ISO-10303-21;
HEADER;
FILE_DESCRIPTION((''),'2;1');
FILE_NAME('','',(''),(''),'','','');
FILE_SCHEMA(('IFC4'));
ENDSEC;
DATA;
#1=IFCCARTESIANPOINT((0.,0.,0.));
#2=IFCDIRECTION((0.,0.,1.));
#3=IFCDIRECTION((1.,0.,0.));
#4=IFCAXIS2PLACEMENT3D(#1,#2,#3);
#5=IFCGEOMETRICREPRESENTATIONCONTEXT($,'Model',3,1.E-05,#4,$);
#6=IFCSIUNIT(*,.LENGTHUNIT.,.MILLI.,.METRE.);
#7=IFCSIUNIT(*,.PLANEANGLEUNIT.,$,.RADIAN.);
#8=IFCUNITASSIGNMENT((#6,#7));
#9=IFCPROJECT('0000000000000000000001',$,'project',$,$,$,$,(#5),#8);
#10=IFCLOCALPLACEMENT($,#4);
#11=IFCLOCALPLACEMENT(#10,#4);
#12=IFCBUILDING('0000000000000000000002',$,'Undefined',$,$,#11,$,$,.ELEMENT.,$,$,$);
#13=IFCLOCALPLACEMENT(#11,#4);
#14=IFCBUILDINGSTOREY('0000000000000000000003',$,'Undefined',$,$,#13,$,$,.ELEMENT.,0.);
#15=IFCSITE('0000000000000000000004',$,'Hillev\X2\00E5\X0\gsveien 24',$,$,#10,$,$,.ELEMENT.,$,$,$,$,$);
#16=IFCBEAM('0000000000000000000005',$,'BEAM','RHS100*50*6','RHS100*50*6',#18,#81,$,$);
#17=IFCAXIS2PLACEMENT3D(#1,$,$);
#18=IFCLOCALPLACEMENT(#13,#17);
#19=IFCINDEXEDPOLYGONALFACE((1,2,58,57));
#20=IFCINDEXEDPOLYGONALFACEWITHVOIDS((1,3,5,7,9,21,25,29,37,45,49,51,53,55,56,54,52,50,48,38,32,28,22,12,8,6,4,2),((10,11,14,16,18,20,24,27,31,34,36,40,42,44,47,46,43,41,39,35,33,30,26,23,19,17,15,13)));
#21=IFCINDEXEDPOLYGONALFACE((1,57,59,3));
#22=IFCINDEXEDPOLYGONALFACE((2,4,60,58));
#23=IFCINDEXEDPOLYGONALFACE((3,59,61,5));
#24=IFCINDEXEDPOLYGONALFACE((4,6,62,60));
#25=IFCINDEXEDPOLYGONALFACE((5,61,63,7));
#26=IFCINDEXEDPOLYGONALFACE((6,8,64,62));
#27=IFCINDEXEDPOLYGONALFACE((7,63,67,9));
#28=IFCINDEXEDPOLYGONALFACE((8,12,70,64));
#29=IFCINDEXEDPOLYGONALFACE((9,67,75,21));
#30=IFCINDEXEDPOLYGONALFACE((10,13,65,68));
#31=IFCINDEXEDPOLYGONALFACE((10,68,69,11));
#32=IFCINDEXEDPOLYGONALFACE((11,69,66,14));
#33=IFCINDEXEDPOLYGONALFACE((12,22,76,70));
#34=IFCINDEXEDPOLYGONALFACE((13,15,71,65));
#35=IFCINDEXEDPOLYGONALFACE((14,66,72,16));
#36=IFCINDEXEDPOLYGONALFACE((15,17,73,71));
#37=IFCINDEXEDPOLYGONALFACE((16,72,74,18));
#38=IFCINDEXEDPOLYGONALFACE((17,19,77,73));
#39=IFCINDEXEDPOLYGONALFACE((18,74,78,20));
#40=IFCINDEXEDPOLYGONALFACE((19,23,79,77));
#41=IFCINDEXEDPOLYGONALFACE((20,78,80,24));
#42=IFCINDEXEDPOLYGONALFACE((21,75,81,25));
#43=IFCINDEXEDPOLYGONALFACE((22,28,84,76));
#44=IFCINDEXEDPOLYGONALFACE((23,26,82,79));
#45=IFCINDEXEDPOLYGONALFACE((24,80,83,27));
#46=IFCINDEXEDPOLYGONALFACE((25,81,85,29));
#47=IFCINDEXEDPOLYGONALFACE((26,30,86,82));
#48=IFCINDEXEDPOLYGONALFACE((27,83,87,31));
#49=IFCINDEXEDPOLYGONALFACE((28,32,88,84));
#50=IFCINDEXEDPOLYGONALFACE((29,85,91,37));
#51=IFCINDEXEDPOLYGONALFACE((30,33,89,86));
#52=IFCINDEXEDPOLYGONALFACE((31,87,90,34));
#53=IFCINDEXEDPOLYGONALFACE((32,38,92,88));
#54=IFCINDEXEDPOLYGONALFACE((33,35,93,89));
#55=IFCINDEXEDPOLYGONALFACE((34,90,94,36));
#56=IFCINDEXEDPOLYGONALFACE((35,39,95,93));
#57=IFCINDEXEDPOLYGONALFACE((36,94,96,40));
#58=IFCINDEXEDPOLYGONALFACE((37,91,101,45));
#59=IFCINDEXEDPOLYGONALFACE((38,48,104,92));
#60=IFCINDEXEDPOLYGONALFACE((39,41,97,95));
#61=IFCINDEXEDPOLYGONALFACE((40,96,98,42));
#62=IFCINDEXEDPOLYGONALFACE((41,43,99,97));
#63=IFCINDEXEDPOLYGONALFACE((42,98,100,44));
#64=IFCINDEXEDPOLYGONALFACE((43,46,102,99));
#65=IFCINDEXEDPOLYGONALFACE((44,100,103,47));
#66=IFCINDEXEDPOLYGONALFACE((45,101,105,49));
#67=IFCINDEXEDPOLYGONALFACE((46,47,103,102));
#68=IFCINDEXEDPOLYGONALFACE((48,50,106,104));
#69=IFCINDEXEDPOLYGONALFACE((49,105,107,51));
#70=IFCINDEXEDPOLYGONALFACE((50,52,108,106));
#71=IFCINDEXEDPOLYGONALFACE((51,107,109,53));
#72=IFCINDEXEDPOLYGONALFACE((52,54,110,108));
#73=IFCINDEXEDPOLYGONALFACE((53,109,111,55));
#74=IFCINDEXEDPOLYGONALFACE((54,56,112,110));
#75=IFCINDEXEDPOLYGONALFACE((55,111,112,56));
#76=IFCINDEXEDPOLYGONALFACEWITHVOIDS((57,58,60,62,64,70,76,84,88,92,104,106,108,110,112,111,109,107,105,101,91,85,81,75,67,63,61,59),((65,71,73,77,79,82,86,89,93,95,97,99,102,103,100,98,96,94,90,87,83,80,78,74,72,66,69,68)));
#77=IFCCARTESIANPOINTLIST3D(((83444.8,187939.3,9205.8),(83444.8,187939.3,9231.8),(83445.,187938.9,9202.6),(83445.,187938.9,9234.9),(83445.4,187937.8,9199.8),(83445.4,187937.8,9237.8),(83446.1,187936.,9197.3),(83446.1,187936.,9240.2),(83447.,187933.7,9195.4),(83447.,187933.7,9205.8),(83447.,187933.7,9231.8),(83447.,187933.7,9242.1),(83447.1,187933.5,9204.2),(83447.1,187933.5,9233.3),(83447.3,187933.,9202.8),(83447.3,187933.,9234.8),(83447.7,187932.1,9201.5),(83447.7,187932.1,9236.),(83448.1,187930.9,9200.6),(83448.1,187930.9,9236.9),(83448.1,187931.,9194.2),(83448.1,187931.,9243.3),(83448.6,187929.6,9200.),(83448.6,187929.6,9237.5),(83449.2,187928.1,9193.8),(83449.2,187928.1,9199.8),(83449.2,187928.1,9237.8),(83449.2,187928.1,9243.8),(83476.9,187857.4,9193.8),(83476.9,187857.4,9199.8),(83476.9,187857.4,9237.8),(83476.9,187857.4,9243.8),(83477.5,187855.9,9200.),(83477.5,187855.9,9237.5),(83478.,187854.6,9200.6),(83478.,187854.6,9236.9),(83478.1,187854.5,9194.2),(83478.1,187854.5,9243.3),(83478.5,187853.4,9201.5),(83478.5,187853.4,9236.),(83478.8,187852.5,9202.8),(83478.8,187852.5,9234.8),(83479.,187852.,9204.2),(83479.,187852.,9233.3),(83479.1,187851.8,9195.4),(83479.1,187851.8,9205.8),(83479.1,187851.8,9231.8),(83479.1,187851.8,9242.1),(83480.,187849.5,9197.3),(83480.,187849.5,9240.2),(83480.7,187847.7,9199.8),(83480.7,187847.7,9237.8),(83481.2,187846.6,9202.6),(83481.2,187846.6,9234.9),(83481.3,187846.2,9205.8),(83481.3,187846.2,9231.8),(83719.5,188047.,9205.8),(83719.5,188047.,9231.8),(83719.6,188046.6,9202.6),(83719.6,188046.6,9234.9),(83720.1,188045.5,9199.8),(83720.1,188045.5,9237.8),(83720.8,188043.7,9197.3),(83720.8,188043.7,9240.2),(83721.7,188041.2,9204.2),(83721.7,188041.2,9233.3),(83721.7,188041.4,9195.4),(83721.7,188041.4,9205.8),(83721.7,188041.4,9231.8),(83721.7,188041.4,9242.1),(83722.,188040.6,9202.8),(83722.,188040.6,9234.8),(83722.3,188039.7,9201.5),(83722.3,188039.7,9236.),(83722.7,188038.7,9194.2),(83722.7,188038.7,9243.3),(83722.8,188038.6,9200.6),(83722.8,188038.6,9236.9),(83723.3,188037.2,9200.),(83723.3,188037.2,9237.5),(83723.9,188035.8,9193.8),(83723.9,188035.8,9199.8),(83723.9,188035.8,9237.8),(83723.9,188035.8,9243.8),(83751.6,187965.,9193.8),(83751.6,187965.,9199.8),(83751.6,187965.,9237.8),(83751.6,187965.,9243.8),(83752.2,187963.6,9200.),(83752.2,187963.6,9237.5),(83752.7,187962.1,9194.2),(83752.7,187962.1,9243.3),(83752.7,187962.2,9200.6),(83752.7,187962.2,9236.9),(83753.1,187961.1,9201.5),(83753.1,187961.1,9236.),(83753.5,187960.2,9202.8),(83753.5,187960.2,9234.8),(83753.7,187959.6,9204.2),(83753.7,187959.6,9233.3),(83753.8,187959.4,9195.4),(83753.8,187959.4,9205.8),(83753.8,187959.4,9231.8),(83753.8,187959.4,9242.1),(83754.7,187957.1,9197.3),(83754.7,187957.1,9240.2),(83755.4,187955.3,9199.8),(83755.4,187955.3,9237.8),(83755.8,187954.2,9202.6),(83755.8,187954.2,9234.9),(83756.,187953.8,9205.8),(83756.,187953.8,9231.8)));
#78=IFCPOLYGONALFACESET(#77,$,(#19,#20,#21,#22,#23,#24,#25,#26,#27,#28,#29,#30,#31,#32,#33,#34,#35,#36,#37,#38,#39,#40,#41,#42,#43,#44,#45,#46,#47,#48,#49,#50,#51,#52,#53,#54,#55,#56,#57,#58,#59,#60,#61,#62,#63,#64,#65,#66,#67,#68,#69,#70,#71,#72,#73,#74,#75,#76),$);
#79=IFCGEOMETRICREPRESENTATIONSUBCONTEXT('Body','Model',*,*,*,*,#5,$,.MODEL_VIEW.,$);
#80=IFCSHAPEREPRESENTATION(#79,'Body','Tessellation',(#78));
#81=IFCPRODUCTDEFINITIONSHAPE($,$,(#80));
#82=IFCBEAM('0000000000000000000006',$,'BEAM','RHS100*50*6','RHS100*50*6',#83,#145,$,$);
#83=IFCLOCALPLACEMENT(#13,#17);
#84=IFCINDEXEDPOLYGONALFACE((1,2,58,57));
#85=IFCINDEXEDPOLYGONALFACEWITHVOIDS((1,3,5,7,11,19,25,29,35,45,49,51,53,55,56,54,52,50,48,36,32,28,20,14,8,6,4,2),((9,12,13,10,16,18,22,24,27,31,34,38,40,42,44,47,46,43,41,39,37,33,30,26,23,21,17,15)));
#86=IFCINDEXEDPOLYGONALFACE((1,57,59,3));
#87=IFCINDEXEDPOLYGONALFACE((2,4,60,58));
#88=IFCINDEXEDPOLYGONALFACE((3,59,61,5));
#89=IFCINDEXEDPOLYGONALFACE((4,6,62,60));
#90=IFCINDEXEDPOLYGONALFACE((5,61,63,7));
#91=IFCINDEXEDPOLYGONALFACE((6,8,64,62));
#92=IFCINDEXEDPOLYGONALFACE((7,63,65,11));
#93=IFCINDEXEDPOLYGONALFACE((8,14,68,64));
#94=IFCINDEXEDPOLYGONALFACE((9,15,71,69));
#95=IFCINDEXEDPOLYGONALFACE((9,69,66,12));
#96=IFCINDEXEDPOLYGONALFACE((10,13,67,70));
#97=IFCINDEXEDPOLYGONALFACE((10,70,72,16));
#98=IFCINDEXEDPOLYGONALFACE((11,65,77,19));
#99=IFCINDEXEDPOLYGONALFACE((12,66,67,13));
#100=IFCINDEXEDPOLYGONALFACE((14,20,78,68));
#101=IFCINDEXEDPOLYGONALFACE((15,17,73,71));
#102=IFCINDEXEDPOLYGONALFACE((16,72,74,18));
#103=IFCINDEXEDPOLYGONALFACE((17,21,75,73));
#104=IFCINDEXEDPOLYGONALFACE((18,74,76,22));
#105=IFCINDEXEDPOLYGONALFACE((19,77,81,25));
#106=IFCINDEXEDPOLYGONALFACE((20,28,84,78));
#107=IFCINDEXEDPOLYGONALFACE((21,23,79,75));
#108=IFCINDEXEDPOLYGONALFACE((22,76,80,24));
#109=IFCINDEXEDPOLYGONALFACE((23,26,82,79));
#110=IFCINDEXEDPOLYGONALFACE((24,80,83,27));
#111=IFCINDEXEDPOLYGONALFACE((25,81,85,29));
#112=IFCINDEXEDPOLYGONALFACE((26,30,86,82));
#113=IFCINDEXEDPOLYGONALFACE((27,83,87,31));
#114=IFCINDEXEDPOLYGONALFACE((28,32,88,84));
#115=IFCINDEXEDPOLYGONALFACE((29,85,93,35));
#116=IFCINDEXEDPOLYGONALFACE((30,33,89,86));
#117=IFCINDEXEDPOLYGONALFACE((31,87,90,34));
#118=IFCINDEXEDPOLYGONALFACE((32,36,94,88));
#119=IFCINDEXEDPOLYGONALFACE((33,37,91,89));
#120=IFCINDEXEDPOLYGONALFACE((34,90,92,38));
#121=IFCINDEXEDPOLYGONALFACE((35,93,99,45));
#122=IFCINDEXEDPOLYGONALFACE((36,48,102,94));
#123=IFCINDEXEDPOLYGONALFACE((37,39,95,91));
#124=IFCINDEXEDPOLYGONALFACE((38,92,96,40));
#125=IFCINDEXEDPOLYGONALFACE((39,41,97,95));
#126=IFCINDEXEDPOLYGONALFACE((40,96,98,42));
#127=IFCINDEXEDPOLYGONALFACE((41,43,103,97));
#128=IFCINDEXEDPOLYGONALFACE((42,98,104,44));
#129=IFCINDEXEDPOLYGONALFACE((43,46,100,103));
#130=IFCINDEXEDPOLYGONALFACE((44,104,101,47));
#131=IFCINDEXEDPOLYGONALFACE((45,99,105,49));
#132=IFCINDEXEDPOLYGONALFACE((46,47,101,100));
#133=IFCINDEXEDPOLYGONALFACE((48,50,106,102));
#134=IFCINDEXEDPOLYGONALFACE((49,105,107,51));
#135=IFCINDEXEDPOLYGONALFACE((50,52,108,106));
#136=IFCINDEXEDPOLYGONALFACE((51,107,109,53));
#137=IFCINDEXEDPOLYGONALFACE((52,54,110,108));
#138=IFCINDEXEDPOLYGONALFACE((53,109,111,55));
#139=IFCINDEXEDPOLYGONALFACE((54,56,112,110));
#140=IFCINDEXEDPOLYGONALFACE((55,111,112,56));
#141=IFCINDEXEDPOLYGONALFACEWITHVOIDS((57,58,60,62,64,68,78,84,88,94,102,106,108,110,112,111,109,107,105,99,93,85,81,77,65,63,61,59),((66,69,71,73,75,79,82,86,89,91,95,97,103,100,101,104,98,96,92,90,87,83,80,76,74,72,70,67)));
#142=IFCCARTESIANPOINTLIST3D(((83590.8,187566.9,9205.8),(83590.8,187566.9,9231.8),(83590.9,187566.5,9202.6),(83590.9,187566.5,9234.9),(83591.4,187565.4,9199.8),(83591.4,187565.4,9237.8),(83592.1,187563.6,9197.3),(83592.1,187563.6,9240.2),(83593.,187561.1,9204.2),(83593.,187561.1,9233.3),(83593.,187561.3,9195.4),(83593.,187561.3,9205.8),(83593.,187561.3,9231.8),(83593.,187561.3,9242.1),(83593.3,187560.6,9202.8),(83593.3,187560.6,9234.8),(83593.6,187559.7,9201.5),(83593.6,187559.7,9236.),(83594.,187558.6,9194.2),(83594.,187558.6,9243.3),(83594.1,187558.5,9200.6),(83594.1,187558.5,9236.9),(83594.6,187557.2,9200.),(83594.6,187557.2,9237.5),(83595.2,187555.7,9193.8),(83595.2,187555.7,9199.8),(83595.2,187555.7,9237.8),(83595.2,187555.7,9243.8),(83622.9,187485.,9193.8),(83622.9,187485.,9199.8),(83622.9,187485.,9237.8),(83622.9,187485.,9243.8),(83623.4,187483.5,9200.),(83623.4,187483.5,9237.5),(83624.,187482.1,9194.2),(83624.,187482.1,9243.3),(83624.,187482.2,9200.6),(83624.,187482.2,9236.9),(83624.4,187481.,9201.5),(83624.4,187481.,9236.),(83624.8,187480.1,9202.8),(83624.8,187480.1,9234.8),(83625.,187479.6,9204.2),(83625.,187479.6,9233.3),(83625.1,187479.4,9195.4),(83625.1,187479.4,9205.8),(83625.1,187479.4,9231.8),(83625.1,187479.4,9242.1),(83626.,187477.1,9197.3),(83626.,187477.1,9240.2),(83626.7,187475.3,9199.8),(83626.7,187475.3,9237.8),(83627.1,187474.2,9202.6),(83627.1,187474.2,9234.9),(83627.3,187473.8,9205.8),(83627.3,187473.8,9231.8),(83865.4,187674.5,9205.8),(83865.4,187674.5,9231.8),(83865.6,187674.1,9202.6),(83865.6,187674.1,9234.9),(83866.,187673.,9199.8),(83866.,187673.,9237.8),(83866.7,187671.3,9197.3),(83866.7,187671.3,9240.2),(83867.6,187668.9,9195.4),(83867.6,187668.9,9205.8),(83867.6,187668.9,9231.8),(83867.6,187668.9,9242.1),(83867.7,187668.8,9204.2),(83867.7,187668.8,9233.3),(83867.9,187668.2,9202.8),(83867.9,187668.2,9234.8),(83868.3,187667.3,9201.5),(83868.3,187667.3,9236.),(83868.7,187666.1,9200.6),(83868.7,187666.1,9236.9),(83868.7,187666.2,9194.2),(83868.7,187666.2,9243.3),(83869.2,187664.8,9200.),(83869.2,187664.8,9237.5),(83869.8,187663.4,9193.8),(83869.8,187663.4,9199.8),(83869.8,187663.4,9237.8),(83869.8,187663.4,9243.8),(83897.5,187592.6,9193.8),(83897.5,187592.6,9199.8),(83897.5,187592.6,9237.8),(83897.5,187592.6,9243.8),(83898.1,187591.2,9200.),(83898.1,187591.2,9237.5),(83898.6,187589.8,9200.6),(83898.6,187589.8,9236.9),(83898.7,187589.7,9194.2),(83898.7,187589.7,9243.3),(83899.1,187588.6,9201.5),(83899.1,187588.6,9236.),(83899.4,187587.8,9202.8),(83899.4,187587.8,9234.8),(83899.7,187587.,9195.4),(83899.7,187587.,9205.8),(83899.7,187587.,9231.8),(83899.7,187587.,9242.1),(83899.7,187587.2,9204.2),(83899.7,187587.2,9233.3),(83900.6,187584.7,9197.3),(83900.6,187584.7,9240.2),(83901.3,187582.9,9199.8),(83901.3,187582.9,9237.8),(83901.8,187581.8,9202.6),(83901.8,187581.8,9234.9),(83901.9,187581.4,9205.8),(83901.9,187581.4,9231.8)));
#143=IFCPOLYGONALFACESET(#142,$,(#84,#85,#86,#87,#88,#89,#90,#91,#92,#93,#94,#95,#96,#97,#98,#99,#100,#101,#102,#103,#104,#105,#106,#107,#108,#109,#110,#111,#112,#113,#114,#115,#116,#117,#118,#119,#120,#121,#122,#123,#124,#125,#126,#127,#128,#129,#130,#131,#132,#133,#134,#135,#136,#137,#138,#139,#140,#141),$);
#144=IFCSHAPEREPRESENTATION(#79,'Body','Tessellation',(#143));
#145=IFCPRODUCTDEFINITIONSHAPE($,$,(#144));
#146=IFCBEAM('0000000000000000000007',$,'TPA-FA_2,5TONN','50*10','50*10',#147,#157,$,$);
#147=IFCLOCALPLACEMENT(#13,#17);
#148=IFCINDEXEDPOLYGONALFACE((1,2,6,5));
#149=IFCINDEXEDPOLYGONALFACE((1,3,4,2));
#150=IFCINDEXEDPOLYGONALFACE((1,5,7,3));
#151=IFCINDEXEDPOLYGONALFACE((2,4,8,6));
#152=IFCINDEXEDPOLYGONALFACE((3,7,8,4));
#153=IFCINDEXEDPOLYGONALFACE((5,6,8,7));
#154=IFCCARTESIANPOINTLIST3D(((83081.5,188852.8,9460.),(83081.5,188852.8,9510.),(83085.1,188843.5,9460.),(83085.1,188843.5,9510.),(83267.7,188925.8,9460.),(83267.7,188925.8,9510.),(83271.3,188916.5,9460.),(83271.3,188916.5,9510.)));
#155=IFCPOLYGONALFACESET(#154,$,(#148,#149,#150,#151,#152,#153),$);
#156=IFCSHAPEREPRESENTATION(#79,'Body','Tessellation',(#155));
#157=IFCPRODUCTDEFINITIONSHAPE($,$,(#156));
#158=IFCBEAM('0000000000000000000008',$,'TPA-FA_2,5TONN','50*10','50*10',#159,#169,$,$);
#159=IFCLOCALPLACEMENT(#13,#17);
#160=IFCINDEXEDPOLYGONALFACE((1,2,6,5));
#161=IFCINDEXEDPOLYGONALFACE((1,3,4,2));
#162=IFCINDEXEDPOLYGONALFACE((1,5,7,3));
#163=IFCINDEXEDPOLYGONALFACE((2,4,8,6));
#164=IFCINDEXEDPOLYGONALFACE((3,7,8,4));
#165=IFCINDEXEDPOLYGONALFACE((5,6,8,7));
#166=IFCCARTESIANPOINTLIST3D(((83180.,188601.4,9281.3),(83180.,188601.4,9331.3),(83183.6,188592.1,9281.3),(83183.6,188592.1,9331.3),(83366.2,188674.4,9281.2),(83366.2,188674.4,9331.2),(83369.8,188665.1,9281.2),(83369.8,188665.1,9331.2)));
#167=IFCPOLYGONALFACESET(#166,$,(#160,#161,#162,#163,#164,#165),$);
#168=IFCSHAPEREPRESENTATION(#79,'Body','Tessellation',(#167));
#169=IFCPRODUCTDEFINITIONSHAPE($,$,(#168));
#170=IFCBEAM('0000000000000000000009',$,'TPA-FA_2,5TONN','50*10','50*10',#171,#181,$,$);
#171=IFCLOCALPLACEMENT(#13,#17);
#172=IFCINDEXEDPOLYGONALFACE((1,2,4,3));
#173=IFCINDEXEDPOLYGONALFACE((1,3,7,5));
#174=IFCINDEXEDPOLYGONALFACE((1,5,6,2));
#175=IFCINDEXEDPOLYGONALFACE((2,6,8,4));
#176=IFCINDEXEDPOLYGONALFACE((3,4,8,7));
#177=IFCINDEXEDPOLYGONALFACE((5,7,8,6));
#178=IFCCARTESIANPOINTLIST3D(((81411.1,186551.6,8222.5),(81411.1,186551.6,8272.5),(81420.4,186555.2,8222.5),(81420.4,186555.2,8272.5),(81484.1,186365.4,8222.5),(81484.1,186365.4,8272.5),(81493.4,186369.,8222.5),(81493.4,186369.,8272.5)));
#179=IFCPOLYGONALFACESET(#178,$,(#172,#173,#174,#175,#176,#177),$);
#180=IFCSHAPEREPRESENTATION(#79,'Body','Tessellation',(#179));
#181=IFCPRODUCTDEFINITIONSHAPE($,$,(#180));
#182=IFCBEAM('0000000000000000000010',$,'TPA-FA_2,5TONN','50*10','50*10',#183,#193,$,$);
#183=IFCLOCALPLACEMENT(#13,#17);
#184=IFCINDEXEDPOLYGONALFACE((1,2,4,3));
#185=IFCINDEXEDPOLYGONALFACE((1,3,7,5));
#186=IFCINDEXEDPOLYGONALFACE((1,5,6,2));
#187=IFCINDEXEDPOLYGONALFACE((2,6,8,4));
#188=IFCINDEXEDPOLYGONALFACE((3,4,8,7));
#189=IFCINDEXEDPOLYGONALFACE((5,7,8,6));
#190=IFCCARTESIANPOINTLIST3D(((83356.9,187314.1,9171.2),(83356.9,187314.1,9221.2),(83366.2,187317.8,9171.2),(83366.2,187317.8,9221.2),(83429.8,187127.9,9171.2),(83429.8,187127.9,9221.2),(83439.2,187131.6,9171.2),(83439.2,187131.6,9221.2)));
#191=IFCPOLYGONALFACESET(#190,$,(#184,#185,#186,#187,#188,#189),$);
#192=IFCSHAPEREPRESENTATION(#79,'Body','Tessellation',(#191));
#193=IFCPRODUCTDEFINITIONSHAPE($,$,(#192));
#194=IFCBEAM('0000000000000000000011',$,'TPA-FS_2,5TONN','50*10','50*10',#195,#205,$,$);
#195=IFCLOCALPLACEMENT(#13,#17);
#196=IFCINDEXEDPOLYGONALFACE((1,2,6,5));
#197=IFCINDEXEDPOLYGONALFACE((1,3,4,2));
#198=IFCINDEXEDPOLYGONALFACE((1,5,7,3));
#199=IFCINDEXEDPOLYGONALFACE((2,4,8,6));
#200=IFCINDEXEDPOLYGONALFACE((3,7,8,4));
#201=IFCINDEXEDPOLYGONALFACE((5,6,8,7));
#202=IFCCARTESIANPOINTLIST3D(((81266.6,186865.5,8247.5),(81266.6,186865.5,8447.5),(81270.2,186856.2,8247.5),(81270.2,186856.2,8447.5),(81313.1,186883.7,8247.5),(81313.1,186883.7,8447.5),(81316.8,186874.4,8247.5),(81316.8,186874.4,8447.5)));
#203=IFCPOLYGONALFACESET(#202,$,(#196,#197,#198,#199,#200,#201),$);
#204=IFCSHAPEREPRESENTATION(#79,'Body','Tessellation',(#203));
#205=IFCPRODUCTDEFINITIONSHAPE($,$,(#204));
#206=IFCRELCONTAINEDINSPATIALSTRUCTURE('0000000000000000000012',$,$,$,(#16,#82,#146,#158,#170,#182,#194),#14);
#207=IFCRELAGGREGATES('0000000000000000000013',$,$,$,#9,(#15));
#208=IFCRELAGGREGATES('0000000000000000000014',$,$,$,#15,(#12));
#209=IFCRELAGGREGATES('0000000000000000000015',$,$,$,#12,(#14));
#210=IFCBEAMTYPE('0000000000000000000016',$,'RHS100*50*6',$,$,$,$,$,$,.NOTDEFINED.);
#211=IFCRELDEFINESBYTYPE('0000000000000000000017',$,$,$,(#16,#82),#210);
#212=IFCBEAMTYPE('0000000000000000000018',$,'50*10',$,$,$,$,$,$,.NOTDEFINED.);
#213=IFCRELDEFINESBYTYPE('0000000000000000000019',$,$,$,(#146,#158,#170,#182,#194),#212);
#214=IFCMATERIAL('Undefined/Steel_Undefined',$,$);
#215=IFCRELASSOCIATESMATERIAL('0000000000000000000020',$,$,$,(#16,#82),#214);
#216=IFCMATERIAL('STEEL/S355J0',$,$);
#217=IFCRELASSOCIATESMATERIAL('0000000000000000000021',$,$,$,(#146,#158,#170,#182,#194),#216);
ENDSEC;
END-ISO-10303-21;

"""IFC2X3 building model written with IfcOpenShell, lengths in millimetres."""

from ifc_helpers import new_model, si_unit, frame, frame_2d, origin_with_axes, place, context, subcontext, project, spatial, rectangle, hollow_rectangle, extrude, material, type_object, element, save


model = new_model("IFC2X3")

# Units and contexts
model_context = context("Model", 3, precision=1e-05, world=origin_with_axes())
body_context = subcontext(model_context, "Body", "Model", "MODEL_VIEW")
ifc_project = project(units=[si_unit("LENGTHUNIT", "METRE", prefix="MILLI"), si_unit("PLANEANGLEUNIT", "RADIAN")], contexts=[model_context])

# Site, building, storey
site_placement = place(None, origin_with_axes())
site = spatial("IfcSite", under=ifc_project, at=site_placement, Name="Hillevågsveien 24", CompositionType="ELEMENT")
building_placement = place(site_placement, origin_with_axes())
building = spatial("IfcBuilding", under=site, at=building_placement, Name="Undefined", CompositionType="ELEMENT")
storey_placement = place(building_placement, origin_with_axes())
storey = spatial("IfcBuildingStorey", under=building, at=storey_placement, Name="Undefined", CompositionType="ELEMENT", Elevation=0.0)

# Shared definitions
ifc_material_1 = material(Name="STEEL/S355J0")

# Beams
ifc_material_2 = material(Name="Undefined/Steel_Undefined")
beam_type_1 = type_object("IfcBeamType", Name="RHS100*50*6", PredefinedType="NOTDEFINED")
for number, where, z_axis, x_axis, name in (
    (1, (83737.7, 188000.4, 9218.8), (0.364877, -0.931056, 0.0), (-0.931056, -0.364877, 0.0), "BEAM"),
    (2, (83883.7, 187628.0, 9218.8), (0.364877, -0.931056, 0.0), (-0.931056, -0.364877, 0.0), "BEAM"),
):
    element("IfcBeam", number, at=place(storey_placement, frame(where, z_axis=z_axis, x_axis=x_axis)), inside=storey, type_object=beam_type_1, material=ifc_material_2, Name=name, Description="RHS100*50*6", ObjectType="RHS100*50*6", context=body_context, shape_type="SweptSolid", body=[
        extrude(hollow_rectangle(XDim=50.0, YDim=100.0, WallThickness=6.0, InnerFilletRadius=6.0, OuterFilletRadius=12.0, at=frame_2d((0.0, 0.0), x_axis=(1.0, 0.0))), frame((295.0, 0.0, 0.0), z_axis=(-1.0, 0.0, 0.0), x_axis=(0.0, -1.0, 0.0)), (0.0, 0.0, 1.0), 295.0),
    ])
beam_type_2 = type_object("IfcBeamType", Name="50*10", PredefinedType="NOTDEFINED")
for number, where, z_axis, x_axis, name in (
    (3, (83269.5, 188921.1, 9485.0), (0.000001, 0.0, 1.0), (-0.931056, -0.364877, 0.000001), "TPA-FA_2,5TONN"),
    (4, (83368.0, 188669.7, 9306.2), (0.000001, 0.0, 1.0), (-0.931056, -0.364877, 0.000001), "TPA-FA_2,5TONN"),
):
    element("IfcBeam", number, at=place(storey_placement, frame(where, z_axis=z_axis, x_axis=x_axis)), inside=storey, type_object=beam_type_2, material=ifc_material_1, Name=name, Description="50*10", ObjectType="50*10", context=body_context, shape_type="SweptSolid", body=[
        extrude(rectangle(XDim=10.0, YDim=50.0, at=frame_2d((0.0, 0.0), x_axis=(1.0, 0.0))), frame((200.0, 0.0, 0.0), z_axis=(-1.0, 0.0, 0.0), x_axis=(0.0, -1.0, 0.0)), (0.0, 0.0, 1.0), 200.0),
    ])
for number, where, z_axis, x_axis, name in (
    (5, (81488.7, 186367.2, 8247.5), (-0.000005, 0.000012, 1.0), (-0.364877, 0.931056, -0.000013), "TPA-FA_2,5TONN"),
    (6, (83434.5, 187129.7, 9196.2), (-0.000005, 0.000012, 1.0), (-0.364877, 0.931056, -0.000013), "TPA-FA_2,5TONN"),
):
    element("IfcBeam", number, at=place(storey_placement, frame(where, z_axis=z_axis, x_axis=x_axis)), inside=storey, type_object=beam_type_2, material=ifc_material_1, Name=name, Description="50*10", ObjectType="50*10", context=body_context, shape_type="SweptSolid", body=[
        extrude(rectangle(XDim=10.0, YDim=50.0, at=frame_2d((0.0, 0.0), x_axis=(1.0, 0.0))), frame((200.0, 0.0, 0.0), z_axis=(-1.0, 0.0, 0.0), x_axis=(0.0, -1.0, 0.0)), (0.0, 0.0, 1.0), 200.0),
    ])
for number, where, z_axis, x_axis, name in (
    (7, (81291.7, 186870.0, 8447.5), (0.931056, 0.364877, 0.0), (0.0, 0.0, -1.0), "TPA-FS_2,5TONN"),
):
    element("IfcBeam", number, at=place(storey_placement, frame(where, z_axis=z_axis, x_axis=x_axis)), inside=storey, type_object=beam_type_2, material=ifc_material_1, Name=name, Description="50*10", ObjectType="50*10", context=body_context, shape_type="SweptSolid", body=[
        extrude(rectangle(XDim=10.0, YDim=50.0, at=frame_2d((0.0, 0.0), x_axis=(1.0, 0.0))), frame((200.0, 0.0, 0.0), z_axis=(-1.0, 0.0, 0.0), x_axis=(0.0, -1.0, 0.0)), (0.0, 0.0, 1.0), 200.0),
    ])

save(model, "model.ifc")
